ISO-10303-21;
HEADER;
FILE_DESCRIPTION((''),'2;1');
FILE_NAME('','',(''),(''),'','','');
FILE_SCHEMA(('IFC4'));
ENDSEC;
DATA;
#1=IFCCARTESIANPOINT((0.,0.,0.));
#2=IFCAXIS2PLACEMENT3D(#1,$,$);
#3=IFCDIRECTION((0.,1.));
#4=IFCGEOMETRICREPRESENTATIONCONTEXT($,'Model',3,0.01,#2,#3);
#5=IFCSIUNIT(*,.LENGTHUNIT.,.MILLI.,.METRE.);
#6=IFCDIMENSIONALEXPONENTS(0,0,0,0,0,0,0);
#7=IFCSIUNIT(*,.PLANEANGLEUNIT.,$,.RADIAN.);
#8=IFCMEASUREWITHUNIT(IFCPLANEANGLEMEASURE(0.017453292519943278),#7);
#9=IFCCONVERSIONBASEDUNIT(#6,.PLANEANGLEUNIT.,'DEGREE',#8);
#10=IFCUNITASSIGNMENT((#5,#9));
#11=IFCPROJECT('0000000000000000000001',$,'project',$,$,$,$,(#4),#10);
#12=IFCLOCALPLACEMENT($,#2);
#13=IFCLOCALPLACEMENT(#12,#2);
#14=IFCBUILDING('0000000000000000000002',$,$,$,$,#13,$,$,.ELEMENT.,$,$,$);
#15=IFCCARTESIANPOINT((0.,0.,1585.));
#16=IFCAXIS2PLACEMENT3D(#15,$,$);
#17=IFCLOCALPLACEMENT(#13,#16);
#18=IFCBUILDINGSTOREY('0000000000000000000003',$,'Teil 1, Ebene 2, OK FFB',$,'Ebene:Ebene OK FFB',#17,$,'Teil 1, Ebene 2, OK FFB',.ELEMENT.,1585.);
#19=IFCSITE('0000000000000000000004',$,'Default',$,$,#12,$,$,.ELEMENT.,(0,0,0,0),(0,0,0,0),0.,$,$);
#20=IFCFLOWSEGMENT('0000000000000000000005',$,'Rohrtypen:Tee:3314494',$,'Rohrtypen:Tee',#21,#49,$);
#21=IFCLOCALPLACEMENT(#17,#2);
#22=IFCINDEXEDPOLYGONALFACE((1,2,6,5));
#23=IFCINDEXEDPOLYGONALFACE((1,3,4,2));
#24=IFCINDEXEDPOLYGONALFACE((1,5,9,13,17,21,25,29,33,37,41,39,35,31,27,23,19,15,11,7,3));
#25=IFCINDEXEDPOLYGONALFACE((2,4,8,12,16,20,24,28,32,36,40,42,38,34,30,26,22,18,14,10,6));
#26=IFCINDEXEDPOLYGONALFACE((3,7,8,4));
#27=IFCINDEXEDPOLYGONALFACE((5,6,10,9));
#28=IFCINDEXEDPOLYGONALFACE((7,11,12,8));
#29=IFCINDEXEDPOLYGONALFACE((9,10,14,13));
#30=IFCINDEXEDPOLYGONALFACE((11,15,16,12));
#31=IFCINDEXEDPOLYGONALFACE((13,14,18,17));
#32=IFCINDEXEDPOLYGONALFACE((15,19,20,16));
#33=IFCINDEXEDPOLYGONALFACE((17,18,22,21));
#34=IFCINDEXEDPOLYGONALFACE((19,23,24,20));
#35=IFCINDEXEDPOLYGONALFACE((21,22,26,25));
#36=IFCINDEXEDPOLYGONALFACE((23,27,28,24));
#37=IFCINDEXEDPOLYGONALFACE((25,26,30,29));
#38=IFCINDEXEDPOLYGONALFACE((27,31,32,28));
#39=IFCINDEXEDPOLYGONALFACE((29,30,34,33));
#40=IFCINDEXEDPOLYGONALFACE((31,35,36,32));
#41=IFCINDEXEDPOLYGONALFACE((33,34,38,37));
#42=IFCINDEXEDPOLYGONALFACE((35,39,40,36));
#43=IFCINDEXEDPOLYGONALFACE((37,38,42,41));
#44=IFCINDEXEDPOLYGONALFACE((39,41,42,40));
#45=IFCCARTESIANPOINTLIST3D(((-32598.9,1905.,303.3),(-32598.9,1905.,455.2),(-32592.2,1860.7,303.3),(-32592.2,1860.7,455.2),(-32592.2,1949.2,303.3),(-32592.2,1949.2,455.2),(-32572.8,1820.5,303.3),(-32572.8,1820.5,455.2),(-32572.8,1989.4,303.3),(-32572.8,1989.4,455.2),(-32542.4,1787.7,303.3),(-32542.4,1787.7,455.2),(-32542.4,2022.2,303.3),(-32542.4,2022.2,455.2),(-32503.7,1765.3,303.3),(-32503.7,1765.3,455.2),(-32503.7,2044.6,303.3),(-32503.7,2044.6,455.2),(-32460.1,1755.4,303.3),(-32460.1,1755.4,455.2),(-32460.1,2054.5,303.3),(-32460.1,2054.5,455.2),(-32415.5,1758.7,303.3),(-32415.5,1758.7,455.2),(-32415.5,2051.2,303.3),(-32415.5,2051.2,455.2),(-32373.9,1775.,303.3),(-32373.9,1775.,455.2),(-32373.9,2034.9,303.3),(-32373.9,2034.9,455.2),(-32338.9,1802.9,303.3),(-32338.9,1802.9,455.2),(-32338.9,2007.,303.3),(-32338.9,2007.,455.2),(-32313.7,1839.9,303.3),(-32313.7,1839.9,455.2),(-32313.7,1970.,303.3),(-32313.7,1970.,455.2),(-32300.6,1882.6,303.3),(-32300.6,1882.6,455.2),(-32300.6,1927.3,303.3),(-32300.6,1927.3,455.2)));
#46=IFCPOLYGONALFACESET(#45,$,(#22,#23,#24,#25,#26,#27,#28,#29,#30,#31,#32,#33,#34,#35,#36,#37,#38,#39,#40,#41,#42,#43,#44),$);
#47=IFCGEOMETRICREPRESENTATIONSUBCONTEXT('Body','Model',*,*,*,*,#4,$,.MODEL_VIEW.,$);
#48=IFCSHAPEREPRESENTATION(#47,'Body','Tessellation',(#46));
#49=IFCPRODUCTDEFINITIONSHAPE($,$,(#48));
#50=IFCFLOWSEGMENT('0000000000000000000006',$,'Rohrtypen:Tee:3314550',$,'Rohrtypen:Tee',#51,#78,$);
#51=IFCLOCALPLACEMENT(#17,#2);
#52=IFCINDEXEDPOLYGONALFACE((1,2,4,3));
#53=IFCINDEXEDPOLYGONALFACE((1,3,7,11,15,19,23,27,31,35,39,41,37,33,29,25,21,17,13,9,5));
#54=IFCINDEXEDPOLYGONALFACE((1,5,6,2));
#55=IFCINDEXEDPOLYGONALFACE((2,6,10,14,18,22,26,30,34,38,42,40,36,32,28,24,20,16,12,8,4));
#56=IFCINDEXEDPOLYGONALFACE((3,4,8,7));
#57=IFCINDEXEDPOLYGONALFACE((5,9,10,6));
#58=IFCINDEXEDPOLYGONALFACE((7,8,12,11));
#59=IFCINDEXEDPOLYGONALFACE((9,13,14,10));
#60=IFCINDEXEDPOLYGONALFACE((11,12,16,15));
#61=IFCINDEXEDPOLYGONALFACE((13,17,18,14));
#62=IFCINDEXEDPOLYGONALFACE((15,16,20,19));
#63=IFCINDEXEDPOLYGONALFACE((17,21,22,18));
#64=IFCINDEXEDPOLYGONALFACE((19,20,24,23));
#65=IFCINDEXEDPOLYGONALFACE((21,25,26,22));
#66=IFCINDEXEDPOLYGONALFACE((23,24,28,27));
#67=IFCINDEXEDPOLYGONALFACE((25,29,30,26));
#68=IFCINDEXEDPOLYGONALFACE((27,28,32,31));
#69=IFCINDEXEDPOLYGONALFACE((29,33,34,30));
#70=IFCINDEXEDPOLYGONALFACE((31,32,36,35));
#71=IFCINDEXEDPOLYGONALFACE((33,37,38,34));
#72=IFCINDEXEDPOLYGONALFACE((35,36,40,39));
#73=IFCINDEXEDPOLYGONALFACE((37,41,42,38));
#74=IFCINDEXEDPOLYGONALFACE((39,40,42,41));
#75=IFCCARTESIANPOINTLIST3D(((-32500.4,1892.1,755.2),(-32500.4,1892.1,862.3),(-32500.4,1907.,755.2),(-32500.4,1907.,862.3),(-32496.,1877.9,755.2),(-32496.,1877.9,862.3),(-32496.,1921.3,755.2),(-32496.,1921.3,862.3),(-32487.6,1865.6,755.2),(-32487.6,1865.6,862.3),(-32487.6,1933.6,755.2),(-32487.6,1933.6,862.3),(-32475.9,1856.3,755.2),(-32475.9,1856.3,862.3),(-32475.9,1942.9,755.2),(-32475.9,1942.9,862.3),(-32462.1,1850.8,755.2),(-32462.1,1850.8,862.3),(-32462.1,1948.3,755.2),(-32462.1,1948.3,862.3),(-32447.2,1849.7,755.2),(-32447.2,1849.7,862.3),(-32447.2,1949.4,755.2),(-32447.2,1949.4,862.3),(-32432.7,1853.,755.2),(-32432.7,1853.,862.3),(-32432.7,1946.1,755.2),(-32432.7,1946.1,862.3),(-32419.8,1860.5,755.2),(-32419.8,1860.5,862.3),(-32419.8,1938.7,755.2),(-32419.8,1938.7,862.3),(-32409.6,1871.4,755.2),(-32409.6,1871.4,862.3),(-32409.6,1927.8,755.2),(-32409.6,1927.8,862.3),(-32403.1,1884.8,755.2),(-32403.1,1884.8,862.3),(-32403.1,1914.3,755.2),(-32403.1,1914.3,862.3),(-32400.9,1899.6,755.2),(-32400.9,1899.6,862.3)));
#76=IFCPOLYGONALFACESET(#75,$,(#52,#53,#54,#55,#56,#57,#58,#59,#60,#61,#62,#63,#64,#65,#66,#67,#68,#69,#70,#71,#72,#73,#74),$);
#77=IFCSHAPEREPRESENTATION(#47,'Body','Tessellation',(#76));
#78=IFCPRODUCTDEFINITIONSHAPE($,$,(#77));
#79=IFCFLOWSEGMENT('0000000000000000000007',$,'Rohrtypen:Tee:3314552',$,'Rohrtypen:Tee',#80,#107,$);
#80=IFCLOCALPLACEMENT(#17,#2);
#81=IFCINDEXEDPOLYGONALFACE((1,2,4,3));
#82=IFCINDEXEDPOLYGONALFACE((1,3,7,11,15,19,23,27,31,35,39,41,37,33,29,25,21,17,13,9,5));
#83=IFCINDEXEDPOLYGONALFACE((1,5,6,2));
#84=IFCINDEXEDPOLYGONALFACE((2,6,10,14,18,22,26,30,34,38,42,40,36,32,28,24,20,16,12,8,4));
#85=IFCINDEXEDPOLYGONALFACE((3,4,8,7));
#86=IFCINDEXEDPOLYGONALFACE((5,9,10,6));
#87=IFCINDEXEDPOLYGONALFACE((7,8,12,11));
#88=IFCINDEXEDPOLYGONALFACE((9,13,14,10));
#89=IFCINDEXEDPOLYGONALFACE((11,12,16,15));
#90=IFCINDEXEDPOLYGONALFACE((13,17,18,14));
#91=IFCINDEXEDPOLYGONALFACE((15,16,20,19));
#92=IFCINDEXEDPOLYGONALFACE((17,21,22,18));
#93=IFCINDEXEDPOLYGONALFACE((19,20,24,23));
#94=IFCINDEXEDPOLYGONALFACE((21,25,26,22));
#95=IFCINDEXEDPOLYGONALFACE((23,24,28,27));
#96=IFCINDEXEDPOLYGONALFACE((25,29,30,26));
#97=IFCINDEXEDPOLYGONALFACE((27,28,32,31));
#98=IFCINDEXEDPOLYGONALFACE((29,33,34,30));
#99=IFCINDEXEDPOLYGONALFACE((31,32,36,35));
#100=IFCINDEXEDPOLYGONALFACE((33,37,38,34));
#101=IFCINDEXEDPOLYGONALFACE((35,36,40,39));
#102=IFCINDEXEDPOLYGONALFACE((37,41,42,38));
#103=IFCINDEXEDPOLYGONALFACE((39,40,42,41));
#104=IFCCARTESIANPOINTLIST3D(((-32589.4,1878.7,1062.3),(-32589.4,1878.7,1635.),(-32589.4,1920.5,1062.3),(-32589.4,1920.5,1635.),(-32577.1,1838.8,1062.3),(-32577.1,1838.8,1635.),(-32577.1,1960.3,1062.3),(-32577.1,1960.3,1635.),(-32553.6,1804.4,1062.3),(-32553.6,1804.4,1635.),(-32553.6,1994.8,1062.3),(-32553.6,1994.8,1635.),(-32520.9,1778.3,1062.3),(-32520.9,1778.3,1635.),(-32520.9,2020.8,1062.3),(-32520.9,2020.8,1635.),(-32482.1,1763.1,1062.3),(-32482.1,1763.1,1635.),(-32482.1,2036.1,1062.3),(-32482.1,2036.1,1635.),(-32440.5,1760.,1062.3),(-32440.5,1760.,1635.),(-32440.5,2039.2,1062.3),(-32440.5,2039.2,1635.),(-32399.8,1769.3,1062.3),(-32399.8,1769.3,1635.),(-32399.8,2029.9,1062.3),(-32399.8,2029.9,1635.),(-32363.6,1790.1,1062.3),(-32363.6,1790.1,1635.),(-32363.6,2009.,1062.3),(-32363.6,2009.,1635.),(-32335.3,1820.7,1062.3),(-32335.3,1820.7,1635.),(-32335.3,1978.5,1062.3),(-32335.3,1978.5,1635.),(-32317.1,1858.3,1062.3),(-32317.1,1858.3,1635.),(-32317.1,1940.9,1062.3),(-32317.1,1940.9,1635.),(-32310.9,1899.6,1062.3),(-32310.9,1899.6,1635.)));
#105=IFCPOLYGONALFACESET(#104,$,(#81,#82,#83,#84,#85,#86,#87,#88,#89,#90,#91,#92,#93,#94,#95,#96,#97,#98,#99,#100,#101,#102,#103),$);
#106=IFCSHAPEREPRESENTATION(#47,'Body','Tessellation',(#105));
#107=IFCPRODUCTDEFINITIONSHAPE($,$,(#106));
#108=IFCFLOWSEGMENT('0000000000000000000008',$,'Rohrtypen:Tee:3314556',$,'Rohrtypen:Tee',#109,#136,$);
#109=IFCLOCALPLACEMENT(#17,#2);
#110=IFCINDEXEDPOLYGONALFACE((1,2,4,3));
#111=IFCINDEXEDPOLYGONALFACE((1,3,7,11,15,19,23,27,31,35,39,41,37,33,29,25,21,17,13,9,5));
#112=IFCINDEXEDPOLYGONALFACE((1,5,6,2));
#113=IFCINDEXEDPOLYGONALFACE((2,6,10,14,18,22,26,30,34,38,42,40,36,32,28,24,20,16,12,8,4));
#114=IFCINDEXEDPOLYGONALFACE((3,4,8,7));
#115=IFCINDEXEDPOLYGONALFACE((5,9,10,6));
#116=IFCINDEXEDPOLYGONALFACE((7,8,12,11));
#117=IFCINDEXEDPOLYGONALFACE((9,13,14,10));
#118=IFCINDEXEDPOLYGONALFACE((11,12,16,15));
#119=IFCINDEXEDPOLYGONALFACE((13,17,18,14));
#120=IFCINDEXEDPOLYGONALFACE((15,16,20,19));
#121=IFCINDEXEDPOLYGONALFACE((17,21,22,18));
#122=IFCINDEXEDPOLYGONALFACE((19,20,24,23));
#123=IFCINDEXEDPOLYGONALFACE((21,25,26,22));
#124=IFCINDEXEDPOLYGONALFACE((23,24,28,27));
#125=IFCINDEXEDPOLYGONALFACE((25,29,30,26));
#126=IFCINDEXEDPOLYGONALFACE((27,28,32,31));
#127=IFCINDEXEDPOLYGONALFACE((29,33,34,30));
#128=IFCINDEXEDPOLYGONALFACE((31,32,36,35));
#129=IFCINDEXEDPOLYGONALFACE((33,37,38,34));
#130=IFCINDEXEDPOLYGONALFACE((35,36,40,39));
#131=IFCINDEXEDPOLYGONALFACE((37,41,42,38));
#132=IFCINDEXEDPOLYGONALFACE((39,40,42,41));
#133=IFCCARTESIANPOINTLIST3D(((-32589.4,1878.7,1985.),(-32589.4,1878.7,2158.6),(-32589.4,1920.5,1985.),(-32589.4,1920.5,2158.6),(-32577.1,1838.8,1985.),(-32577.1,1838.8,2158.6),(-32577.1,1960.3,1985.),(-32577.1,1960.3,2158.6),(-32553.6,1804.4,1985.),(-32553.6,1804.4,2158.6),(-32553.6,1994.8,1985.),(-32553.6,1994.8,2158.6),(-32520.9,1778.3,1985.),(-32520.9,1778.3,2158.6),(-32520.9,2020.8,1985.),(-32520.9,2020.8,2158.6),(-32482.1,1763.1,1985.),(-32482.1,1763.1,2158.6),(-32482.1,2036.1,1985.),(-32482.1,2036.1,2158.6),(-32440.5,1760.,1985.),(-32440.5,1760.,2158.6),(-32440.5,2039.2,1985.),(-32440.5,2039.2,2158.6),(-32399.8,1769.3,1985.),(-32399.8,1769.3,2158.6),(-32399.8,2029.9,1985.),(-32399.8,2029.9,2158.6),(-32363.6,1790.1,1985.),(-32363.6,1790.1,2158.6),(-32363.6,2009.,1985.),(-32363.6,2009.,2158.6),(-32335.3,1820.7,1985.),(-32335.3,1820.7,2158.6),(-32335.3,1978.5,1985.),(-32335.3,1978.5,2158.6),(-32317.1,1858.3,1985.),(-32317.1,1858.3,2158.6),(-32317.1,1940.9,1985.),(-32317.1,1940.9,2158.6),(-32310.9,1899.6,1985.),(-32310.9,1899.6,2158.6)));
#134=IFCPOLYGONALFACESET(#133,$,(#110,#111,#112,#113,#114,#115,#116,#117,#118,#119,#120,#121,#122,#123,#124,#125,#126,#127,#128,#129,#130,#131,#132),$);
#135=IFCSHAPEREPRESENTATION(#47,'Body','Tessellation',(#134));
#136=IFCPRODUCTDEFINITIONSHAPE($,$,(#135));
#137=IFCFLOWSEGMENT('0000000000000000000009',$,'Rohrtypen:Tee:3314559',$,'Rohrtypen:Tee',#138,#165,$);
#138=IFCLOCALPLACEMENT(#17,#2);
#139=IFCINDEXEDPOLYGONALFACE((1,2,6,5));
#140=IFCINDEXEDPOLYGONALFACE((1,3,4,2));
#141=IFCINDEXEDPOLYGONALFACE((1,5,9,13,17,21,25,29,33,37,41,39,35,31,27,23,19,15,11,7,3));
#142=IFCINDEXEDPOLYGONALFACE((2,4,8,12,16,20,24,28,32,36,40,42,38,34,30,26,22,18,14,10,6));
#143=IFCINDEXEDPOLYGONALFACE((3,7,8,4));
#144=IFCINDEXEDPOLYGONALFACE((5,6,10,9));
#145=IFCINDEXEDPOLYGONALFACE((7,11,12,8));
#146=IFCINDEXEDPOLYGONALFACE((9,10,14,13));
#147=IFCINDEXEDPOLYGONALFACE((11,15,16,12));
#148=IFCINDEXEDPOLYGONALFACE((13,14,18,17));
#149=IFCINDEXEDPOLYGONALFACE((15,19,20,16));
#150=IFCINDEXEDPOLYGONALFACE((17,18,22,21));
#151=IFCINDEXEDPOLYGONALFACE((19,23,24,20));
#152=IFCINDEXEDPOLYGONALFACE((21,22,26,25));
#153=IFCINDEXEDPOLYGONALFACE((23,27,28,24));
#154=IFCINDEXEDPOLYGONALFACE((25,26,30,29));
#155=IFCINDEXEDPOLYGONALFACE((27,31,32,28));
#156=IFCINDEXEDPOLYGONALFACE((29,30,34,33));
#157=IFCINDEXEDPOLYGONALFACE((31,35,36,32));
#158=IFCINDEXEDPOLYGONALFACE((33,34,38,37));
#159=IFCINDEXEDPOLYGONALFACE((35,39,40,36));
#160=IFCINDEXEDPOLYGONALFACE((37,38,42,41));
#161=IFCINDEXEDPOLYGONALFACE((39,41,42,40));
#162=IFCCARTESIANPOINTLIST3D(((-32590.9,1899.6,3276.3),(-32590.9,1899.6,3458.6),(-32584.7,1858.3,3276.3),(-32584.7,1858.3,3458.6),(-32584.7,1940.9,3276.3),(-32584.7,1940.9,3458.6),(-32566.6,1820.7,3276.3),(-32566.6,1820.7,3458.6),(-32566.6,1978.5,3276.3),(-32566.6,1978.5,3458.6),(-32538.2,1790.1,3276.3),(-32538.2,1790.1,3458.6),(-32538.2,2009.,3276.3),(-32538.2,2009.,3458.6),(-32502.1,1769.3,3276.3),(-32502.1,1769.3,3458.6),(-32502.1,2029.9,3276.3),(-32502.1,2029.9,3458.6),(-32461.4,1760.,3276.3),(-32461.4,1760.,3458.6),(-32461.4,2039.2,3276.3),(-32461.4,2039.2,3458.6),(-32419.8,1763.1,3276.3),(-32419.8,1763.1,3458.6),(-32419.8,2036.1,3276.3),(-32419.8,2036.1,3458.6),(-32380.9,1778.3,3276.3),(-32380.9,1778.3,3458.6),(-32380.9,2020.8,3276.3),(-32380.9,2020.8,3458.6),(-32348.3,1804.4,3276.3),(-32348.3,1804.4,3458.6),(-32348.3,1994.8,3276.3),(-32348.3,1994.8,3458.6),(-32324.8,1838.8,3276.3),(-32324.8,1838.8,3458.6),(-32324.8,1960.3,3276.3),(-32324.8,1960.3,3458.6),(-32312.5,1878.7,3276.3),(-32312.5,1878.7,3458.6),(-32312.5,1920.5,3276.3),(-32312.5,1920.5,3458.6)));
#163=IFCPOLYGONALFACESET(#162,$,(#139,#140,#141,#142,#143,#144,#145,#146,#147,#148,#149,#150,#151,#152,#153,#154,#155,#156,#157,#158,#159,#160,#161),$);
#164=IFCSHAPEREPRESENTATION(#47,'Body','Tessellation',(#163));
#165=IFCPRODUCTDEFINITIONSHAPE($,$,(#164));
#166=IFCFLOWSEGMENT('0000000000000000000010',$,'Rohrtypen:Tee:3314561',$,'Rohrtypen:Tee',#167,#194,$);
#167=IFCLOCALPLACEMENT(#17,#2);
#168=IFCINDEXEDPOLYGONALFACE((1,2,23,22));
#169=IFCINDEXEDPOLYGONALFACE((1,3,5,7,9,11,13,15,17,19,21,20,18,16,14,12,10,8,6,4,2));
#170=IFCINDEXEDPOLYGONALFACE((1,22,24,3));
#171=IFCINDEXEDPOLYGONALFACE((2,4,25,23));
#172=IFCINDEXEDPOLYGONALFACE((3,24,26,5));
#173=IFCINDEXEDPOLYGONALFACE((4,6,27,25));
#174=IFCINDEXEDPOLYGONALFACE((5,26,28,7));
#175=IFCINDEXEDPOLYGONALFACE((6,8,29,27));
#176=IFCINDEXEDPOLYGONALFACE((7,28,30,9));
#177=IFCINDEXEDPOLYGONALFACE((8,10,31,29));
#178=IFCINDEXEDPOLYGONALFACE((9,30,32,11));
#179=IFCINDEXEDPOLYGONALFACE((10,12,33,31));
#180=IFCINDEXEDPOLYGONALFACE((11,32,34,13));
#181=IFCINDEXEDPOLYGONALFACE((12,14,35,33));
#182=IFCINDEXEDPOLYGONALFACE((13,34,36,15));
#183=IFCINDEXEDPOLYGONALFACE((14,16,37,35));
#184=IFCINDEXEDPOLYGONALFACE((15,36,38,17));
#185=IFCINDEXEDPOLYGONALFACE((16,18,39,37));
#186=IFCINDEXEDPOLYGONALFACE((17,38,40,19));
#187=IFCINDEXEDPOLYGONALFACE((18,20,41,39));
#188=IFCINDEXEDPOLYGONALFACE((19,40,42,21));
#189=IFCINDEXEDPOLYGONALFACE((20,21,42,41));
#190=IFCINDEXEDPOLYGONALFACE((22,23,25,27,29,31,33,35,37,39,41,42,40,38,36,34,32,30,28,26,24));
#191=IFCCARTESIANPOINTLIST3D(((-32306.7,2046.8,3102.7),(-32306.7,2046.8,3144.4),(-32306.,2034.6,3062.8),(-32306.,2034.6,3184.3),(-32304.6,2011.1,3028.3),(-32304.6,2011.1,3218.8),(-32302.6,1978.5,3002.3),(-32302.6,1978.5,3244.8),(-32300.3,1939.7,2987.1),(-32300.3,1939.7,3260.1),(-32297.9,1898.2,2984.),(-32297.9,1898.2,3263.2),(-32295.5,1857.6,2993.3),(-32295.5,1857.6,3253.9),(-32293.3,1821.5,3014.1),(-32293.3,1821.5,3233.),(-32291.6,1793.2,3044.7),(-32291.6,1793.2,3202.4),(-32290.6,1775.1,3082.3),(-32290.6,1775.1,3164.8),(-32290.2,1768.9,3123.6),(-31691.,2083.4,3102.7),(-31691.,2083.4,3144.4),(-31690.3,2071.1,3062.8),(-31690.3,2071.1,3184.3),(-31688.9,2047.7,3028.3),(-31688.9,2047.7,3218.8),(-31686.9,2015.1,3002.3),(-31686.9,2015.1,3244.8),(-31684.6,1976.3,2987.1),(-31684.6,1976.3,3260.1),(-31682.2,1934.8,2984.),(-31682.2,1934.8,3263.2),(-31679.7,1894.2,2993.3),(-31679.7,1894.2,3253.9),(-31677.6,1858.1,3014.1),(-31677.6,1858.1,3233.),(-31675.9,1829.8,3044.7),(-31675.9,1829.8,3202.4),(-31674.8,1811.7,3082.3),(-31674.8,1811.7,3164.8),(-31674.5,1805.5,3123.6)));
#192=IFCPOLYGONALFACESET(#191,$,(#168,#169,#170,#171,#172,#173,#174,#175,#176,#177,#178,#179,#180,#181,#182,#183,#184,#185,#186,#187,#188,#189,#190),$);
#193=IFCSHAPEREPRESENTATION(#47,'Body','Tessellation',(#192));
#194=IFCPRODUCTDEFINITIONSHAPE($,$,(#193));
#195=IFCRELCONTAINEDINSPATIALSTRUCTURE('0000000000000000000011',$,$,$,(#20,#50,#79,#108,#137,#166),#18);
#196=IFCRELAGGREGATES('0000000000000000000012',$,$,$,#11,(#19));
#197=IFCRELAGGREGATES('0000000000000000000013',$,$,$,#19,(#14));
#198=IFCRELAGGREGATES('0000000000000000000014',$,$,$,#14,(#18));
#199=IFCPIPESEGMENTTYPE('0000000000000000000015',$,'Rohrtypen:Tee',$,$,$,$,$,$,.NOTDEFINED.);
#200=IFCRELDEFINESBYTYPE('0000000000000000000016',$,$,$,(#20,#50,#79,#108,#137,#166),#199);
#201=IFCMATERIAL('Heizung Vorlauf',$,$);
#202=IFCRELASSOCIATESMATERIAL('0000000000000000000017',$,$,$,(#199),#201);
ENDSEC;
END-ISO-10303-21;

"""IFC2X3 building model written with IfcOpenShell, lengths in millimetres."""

from ifc_helpers import new_model, entity, si_unit, converted_unit, direction, frame, frame_2d, origin, origin_2d_with_axis, place, context, subcontext, project, spatial, circle, extrude, material, type_object, element, save


model = new_model("IFC2X3")

# Units and contexts
model_context = context("Model", 3, precision=0.01, world=origin(), true_north=direction((0.0, 1.0)))
body_context = subcontext(model_context, "Body", "Model", "MODEL_VIEW")
ifc_project = project(units=[si_unit("LENGTHUNIT", "METRE", prefix="MILLI"), converted_unit("PLANEANGLEUNIT", "DEGREE", entity("IfcPlaneAngleMeasure", 0.017453292519943278), si_unit("PLANEANGLEUNIT", "RADIAN"), dimensions=[0, 0, 0, 0, 0, 0, 0])], contexts=[model_context])

# Site, building, storey
site_placement = place(None, origin())
site = spatial("IfcSite", under=ifc_project, at=site_placement, Name="Default", CompositionType="ELEMENT", RefLatitude=(0, 0, 0, 0), RefLongitude=(0, 0, 0, 0), RefElevation=0.0)
building_placement = place(site_placement, origin())
building = spatial("IfcBuilding", under=site, at=building_placement, CompositionType="ELEMENT")
storey_placement = place(building_placement, frame((0.0, 0.0, 1585.0)))
storey = spatial("IfcBuildingStorey", under=building, at=storey_placement, Name="Teil 1, Ebene 2, OK FFB", ObjectType="Ebene:Ebene OK FFB", LongName="Teil 1, Ebene 2, OK FFB", CompositionType="ELEMENT", Elevation=1585.0)

# Flow segments
ifc_material = material(Name="Heizung Vorlauf")
pipe_segment_type = type_object("IfcPipeSegmentType", Name="Rohrtypen:Tee", PredefinedType="NOTDEFINED", material=ifc_material)
flow_segment_1_placement = place(storey_placement, origin())
element("IfcFlowSegment", 1, at=flow_segment_1_placement, inside=storey, type_object=pipe_segment_type, Name="Rohrtypen:Tee:3314494", ObjectType="Rohrtypen:Tee", context=body_context, shape_type="SweptSolid", body=[
    extrude(circle(Radius=150.0, at=frame_2d((0.0, 0.0), x_axis=(1.0, 0.0))), frame((-32448.9, 1905.0, 303.3), z_axis=(0.0, 0.0, 1.0), x_axis=(-1.0, 0.0, 0.0)), (0.0, 0.0, 1.0), 151.9),
])
flow_segment_2_placement = place(storey_placement, origin())
element("IfcFlowSegment", 2, at=flow_segment_2_placement, inside=storey, type_object=pipe_segment_type, Name="Rohrtypen:Tee:3314550", ObjectType="Rohrtypen:Tee", context=body_context, shape_type="SweptSolid", body=[
    extrude(circle(Radius=50.0, at=frame_2d((0.0, 0.0), x_axis=(1.0, 0.0))), frame((-32450.9, 1899.6, 755.2)), (0.0, 0.0, 1.0), 107.2),
])
flow_segment_3_placement = place(storey_placement, origin())
element("IfcFlowSegment", 3, at=flow_segment_3_placement, inside=storey, type_object=pipe_segment_type, Name="Rohrtypen:Tee:3314552", ObjectType="Rohrtypen:Tee", context=body_context, shape_type="SweptSolid", body=[
    extrude(circle(Radius=140.0, at=frame_2d((0.0, 0.0), x_axis=(1.0, 0.0))), frame((-32450.9, 1899.6, 1062.3)), (0.0, 0.0, 1.0), 572.7),
])
flow_segment_4_placement = place(storey_placement, origin())
element("IfcFlowSegment", 4, at=flow_segment_4_placement, inside=storey, type_object=pipe_segment_type, Name="Rohrtypen:Tee:3314556", ObjectType="Rohrtypen:Tee", context=body_context, shape_type="SweptSolid", body=[
    extrude(circle(Radius=140.0, at=origin_2d_with_axis()), frame((-32450.9, 1899.6, 1985.0)), (0.0, 0.0, 1.0), 173.6),
])
flow_segment_5_placement = place(storey_placement, origin())
element("IfcFlowSegment", 5, at=flow_segment_5_placement, inside=storey, type_object=pipe_segment_type, Name="Rohrtypen:Tee:3314559", ObjectType="Rohrtypen:Tee", context=body_context, shape_type="SweptSolid", body=[
    extrude(circle(Radius=140.0, at=origin_2d_with_axis()), frame((-32450.9, 1899.6, 3276.3), z_axis=(0.0, 0.0, 1.0), x_axis=(-1.0, 0.0, 0.0)), (0.0, 0.0, 1.0), 182.3),
])
flow_segment_6_placement = place(storey_placement, origin())
element("IfcFlowSegment", 6, at=flow_segment_6_placement, inside=storey, type_object=pipe_segment_type, Name="Rohrtypen:Tee:3314561", ObjectType="Rohrtypen:Tee", context=body_context, shape_type="SweptSolid", body=[
    extrude(circle(Radius=140.0, at=frame_2d((0.0, 0.0), x_axis=(1.0, 0.0))), frame((-32298.5, 1908.6, 3123.6), z_axis=(0.998239, 0.059319, 0.0), x_axis=(0.059319, -0.998239, 0.0)), (0.0, 0.0, 1.0), 616.8),
])

save(model, "model.ifc")
